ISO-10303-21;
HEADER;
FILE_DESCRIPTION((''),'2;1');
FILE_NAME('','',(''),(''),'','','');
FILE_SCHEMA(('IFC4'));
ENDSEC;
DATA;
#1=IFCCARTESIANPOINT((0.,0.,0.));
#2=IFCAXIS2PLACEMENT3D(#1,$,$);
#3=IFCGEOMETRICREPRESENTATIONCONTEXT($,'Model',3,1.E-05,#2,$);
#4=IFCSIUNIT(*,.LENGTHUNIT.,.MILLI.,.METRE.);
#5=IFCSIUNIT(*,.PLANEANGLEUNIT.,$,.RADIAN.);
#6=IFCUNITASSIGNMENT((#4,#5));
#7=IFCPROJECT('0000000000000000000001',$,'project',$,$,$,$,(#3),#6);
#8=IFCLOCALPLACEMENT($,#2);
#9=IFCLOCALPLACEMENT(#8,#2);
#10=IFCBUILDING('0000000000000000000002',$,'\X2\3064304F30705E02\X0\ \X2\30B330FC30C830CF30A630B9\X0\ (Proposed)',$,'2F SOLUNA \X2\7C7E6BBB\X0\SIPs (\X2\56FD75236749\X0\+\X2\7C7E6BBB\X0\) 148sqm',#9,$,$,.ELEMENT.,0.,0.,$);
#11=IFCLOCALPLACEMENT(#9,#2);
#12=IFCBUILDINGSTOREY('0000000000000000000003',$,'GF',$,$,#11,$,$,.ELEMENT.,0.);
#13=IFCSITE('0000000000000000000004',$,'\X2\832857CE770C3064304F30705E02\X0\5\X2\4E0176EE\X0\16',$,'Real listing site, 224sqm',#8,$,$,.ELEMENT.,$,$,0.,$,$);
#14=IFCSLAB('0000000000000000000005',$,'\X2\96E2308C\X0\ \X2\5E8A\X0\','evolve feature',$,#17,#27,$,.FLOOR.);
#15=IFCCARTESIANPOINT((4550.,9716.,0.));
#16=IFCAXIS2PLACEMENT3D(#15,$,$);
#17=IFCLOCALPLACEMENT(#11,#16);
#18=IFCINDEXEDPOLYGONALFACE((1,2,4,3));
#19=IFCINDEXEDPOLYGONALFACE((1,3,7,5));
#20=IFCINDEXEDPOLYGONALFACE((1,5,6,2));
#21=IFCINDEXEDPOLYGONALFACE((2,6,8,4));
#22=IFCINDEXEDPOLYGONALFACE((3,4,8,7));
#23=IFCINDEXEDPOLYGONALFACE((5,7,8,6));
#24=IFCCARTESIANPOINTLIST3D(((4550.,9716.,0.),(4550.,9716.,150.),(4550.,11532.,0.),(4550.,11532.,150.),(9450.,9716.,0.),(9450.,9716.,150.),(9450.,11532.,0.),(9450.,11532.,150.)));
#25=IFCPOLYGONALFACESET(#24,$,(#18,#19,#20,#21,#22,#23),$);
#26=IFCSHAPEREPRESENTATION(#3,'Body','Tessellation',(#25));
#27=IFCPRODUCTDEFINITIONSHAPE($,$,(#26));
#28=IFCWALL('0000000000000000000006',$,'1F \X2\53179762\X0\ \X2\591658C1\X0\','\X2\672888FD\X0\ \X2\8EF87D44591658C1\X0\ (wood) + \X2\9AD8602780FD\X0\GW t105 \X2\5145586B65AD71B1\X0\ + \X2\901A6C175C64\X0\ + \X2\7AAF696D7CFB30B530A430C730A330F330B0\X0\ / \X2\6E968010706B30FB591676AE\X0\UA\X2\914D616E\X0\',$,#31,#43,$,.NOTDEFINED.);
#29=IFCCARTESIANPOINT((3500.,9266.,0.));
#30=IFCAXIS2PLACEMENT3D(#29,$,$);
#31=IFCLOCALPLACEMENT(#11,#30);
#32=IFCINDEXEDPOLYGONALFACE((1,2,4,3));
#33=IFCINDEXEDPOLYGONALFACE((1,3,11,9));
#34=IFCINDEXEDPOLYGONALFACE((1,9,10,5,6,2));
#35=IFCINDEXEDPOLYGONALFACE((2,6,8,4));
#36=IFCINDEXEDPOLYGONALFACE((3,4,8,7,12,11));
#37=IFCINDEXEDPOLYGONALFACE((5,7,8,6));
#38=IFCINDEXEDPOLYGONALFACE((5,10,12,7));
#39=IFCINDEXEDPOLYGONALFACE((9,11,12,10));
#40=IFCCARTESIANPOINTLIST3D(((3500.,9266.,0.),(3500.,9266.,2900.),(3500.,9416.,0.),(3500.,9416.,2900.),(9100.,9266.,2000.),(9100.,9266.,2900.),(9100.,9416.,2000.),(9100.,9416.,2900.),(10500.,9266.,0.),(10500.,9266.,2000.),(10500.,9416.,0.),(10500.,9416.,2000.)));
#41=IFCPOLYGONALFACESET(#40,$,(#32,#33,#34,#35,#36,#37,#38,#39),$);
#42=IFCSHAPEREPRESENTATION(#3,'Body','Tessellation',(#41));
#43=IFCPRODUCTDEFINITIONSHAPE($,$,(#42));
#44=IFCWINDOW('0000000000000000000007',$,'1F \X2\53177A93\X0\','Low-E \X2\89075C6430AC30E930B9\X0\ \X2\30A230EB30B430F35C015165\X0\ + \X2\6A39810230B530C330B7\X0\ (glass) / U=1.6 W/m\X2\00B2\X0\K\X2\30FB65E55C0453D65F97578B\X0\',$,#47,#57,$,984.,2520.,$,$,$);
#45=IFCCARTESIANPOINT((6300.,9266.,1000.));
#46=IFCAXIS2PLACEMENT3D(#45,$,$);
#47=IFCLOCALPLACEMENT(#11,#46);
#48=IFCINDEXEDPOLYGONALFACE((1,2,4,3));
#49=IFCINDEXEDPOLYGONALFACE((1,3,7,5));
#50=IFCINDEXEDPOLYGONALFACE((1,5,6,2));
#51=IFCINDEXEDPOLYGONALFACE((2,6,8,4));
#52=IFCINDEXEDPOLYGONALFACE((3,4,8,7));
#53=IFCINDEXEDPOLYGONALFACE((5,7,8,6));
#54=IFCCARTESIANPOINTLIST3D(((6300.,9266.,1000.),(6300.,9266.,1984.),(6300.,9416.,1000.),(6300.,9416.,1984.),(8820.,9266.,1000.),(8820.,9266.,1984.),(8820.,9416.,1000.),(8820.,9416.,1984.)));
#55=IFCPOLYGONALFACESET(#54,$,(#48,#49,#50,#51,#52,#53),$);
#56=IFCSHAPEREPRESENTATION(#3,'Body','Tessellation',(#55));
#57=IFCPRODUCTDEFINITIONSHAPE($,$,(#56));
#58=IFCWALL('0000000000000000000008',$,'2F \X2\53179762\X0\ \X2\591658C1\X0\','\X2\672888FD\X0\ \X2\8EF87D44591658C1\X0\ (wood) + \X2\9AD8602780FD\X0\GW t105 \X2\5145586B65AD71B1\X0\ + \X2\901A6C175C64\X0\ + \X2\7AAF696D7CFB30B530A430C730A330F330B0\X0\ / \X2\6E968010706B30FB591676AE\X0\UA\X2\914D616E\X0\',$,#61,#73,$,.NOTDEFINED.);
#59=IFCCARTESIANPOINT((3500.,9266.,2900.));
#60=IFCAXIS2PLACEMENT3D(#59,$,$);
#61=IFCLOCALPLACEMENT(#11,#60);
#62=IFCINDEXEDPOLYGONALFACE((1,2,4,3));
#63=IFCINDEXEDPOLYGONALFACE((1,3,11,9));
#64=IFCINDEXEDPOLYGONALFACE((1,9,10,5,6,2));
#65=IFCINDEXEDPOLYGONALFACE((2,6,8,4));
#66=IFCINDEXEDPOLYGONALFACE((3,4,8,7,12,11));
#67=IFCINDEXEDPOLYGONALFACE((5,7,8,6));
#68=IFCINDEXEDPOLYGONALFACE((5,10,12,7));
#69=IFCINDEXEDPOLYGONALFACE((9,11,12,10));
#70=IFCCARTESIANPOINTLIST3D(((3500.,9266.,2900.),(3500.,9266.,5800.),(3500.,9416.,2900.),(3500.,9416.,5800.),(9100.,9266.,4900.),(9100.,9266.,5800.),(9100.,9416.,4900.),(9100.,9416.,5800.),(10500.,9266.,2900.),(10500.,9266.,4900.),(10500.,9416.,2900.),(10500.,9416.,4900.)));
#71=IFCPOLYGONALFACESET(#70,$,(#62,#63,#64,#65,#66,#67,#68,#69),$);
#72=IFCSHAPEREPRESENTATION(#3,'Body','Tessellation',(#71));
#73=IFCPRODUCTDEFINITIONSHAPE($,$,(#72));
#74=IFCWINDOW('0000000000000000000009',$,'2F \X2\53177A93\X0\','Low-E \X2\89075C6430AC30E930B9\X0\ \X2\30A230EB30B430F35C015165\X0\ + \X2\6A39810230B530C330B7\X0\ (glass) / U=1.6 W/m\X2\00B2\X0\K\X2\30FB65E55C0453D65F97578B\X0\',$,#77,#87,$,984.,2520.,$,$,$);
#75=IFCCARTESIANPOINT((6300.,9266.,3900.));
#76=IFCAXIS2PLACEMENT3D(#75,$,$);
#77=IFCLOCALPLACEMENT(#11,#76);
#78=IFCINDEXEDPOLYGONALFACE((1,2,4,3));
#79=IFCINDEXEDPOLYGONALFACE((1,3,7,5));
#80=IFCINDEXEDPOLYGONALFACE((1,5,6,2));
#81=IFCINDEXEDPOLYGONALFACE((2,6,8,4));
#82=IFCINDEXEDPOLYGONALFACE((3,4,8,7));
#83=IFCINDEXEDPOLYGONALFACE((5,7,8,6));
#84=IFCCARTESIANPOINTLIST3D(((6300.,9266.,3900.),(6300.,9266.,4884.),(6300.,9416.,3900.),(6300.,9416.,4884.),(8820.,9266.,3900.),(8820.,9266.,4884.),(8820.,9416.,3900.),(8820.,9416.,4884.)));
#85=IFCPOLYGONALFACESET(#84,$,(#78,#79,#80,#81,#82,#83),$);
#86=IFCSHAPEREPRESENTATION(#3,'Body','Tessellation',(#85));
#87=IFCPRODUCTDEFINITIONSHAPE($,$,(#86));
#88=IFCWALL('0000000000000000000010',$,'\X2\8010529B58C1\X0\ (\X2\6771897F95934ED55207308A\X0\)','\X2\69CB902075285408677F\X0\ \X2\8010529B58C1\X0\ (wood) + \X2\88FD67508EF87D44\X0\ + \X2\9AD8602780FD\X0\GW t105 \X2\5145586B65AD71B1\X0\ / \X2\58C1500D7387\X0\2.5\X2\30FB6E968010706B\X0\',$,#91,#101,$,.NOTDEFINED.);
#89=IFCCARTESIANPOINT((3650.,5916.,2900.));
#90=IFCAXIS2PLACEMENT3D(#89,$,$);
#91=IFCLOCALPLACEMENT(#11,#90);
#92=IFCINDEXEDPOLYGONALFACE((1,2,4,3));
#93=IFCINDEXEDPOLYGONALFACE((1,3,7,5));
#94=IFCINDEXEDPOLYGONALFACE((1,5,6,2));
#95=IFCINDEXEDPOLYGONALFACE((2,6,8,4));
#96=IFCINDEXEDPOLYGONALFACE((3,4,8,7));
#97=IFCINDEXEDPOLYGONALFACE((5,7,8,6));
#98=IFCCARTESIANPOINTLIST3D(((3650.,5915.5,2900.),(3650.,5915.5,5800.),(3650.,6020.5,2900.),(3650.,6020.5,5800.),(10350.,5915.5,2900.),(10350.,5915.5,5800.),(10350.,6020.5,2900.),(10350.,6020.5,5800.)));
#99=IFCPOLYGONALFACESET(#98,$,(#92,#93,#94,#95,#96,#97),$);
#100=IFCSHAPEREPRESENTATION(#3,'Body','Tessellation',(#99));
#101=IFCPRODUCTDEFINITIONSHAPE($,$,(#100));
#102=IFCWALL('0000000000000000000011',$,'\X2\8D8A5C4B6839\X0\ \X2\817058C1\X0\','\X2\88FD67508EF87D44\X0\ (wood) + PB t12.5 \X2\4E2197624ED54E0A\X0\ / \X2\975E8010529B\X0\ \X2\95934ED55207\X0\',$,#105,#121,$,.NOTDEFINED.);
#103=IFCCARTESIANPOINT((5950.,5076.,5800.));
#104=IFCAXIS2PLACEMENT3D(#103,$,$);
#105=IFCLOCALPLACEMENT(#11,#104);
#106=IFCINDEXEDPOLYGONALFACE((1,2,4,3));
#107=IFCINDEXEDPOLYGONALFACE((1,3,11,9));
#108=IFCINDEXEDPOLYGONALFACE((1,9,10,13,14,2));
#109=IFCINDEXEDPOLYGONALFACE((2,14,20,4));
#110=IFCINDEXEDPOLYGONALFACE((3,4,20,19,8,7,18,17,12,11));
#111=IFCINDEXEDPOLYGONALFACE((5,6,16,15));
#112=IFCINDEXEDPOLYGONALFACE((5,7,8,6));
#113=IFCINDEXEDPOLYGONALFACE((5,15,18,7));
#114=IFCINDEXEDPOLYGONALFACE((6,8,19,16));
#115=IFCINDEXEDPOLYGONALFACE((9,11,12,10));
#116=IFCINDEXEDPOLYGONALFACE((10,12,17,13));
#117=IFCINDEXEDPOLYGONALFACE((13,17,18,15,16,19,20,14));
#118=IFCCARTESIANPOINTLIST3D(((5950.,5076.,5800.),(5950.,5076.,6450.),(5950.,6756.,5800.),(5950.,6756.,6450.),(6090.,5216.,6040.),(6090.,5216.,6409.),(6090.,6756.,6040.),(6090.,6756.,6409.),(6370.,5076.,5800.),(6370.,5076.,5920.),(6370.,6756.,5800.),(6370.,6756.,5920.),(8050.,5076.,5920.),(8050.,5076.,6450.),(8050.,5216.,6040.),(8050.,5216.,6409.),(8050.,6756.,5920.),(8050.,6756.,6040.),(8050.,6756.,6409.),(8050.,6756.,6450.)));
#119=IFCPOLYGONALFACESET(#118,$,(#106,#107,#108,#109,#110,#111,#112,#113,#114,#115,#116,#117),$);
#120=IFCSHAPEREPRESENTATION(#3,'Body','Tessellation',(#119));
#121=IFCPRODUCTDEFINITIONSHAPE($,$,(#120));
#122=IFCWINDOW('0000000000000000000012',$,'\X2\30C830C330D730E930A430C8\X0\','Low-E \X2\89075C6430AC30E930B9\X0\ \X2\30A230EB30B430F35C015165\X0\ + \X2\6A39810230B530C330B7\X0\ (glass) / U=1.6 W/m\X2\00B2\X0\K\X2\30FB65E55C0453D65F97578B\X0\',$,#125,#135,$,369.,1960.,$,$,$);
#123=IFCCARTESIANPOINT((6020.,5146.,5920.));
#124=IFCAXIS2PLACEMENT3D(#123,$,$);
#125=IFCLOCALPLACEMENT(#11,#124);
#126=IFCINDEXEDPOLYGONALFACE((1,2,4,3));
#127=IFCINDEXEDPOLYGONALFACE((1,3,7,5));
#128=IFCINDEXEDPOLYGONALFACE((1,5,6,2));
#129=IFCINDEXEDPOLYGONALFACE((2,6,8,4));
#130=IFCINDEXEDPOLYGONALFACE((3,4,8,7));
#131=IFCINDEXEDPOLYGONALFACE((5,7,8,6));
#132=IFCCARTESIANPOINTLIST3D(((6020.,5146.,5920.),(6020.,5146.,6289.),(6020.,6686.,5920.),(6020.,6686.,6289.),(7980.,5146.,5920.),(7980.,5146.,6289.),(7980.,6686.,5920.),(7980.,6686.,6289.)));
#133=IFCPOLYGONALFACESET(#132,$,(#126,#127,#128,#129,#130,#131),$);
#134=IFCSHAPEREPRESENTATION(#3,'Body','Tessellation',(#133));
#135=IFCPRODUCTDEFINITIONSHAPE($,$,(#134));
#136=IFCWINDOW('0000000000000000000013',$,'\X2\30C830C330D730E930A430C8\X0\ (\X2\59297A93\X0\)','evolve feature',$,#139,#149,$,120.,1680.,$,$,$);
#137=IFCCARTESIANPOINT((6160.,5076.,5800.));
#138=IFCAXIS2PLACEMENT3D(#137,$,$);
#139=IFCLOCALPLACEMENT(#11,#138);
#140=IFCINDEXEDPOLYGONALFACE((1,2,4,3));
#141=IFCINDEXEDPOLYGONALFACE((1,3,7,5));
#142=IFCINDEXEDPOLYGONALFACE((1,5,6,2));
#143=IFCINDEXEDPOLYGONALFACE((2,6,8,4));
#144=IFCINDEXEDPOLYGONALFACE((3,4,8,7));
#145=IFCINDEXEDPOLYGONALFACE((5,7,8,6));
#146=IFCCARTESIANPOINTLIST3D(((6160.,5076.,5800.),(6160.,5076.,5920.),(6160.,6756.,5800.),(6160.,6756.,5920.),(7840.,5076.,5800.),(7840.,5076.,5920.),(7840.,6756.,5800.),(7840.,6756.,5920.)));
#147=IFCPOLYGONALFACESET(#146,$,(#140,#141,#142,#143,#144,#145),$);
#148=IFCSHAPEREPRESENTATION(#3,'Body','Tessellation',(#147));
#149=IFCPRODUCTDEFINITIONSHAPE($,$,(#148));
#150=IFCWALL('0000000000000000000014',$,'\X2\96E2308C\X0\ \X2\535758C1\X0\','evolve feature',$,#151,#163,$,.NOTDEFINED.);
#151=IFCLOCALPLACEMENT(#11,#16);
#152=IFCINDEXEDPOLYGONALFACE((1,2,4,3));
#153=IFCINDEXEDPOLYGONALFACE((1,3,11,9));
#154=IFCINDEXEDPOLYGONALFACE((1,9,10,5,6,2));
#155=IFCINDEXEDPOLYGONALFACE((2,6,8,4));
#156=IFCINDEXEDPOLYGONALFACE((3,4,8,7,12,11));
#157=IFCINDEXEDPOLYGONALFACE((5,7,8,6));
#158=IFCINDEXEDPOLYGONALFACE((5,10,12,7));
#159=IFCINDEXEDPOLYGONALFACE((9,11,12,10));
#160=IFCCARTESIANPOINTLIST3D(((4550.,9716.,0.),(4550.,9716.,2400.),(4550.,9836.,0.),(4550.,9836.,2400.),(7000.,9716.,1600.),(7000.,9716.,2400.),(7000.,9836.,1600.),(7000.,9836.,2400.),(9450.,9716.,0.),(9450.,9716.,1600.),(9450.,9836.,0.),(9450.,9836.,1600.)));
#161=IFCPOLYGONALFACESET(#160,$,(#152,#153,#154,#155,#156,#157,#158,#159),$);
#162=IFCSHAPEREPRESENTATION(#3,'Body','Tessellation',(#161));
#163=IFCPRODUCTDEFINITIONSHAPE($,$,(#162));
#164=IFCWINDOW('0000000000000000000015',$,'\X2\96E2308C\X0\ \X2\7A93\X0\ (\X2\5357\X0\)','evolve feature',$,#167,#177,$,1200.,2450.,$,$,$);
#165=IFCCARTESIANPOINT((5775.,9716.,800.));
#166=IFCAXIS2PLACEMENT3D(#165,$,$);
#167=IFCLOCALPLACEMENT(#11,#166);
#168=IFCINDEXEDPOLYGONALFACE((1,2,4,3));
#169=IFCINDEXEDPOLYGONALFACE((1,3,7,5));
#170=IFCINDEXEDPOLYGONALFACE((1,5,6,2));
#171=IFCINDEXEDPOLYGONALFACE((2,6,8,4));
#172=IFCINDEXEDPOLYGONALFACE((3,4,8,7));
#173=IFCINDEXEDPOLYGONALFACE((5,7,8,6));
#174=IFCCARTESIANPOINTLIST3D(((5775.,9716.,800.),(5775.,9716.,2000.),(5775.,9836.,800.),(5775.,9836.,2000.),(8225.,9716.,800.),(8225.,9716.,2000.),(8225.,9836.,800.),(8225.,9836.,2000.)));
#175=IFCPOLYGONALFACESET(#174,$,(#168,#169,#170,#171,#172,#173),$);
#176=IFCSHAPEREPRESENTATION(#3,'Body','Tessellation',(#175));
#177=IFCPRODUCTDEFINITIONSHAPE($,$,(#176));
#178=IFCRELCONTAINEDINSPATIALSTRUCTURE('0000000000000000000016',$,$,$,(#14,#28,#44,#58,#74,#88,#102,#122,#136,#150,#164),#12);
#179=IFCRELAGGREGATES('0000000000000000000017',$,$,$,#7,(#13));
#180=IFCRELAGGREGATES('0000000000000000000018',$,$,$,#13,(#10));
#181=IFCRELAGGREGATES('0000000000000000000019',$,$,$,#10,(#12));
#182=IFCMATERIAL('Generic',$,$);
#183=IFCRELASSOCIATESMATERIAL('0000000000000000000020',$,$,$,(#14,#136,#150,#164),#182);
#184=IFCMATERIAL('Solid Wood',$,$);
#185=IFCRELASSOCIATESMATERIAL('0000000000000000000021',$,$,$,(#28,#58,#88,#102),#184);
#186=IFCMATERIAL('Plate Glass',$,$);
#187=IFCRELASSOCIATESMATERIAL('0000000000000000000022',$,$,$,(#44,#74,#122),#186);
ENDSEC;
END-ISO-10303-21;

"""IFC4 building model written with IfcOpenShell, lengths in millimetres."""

from ifc_helpers import new_model, si_unit, frame, frame_2d, origin, place, context, project, spatial, rectangle, extrude, material, element, fill, save


model = new_model("IFC4")

# Units and contexts
model_context = context("Model", 3, precision=1e-05, world=origin())
ifc_project = project(units=[si_unit("LENGTHUNIT", "METRE", prefix="MILLI"), si_unit("PLANEANGLEUNIT", "RADIAN")], contexts=[model_context])

# Site, building, storey
site_placement = place(None, origin())
site = spatial("IfcSite", under=ifc_project, at=site_placement, Name="茨城県つくば市5丁目16", ObjectType="Real listing site, 224sqm", CompositionType="ELEMENT", RefElevation=0.0)
building_placement = place(site_placement, origin())
building = spatial("IfcBuilding", under=site, at=building_placement, Name="つくば市 コートハウス (Proposed)", ObjectType="2F SOLUNA 籾殻SIPs (国産杉+籾殻) 148sqm", CompositionType="ELEMENT", ElevationOfRefHeight=0.0, ElevationOfTerrain=0.0)
storey_placement = place(building_placement, origin())
storey = spatial("IfcBuildingStorey", under=building, at=storey_placement, Name="GF", CompositionType="ELEMENT", Elevation=0.0)

# Slab
ifc_material_1 = material(Name="Generic")
slab_placement = place(storey_placement, frame((4550.0, 9716.0, 0.0)))
element("IfcSlab", 1, at=slab_placement, inside=storey, material=ifc_material_1, Name="離れ 床", Description="evolve feature", PredefinedType="FLOOR", context=model_context, shape_type="SweptSolid", body=[
    extrude(rectangle(XDim=4900.0, YDim=1816.0, at=frame_2d((2450.0, 908.0))), frame((4550.0, 9716.0, 0.0)), (0.0, 0.0, 1.0), 150.0),
])

# Wall, opening, window
ifc_material_2 = material(Name="Solid Wood")
wall_1_placement = place(storey_placement, frame((3500.0, 9266.0, 0.0)))
wall_1 = element("IfcWall", 2, at=wall_1_placement, inside=storey, material=ifc_material_2, Name="1F 北面 外壁", Description="木製 軸組外壁 (wood) + 高性能GW t105 充填断熱 + 通気層 + 窯業系サイディング / 準耐火・外皮UA配慮", PredefinedType="NOTDEFINED", context=model_context, shape_type="SweptSolid", body=[
    extrude(rectangle(XDim=7000.0, YDim=150.0, at=frame_2d((3500.0, 75.0))), frame((3500.0, 9266.0, 0.0)), (0.0, 0.0, 1.0), 2900.0),
])
opening_1_placement = place(storey_placement, frame((6300.0, 9266.0, 1000.0)))
opening_1 = element("IfcOpeningElement", 3, at=opening_1_placement, cuts=wall_1, PredefinedType="NOTDEFINED", context=model_context, shape_type="SweptSolid", body=[
    extrude(rectangle(XDim=2520.0, YDim=150.0, at=frame_2d((1260.0, 75.0))), frame((6300.0, 9266.0, 1000.0)), (0.0, 0.0, 1.0), 984.0),
])
ifc_material_3 = material(Name="Plate Glass")
window_1_placement = place(storey_placement, frame((6300.0, 9266.0, 1000.0)))
window_1 = element("IfcWindow", 4, at=window_1_placement, inside=storey, material=ifc_material_3, Name="1F 北窓", Description="Low-E 複層ガラス アルゴン封入 + 樹脂サッシ (glass) / U=1.6 W/m²K・日射取得型", OverallHeight=984.0, OverallWidth=2520.0, context=model_context, shape_type="SweptSolid", body=[
    extrude(rectangle(XDim=2520.0, YDim=150.0, at=frame_2d((1260.0, 75.0))), frame((6300.0, 9266.0, 1000.0)), (0.0, 0.0, 1.0), 984.0),
])
fill(opening_1, window_1)

# Wall, opening, window
wall_2_placement = place(storey_placement, frame((3500.0, 9266.0, 2900.0)))
wall_2 = element("IfcWall", 5, at=wall_2_placement, inside=storey, material=ifc_material_2, Name="2F 北面 外壁", Description="木製 軸組外壁 (wood) + 高性能GW t105 充填断熱 + 通気層 + 窯業系サイディング / 準耐火・外皮UA配慮", PredefinedType="NOTDEFINED", context=model_context, shape_type="SweptSolid", body=[
    extrude(rectangle(XDim=7000.0, YDim=150.0, at=frame_2d((3500.0, 75.0))), frame((3500.0, 9266.0, 2900.0)), (0.0, 0.0, 1.0), 2900.0),
])
opening_2_placement = place(storey_placement, frame((6300.0, 9266.0, 3900.0)))
opening_2 = element("IfcOpeningElement", 6, at=opening_2_placement, cuts=wall_2, PredefinedType="NOTDEFINED", context=model_context, shape_type="SweptSolid", body=[
    extrude(rectangle(XDim=2520.0, YDim=150.0, at=frame_2d((1260.0, 75.0))), frame((6300.0, 9266.0, 3900.0)), (0.0, 0.0, 1.0), 984.0),
])
window_2_placement = place(storey_placement, frame((6300.0, 9266.0, 3900.0)))
window_2 = element("IfcWindow", 7, at=window_2_placement, inside=storey, material=ifc_material_3, Name="2F 北窓", Description="Low-E 複層ガラス アルゴン封入 + 樹脂サッシ (glass) / U=1.6 W/m²K・日射取得型", OverallHeight=984.0, OverallWidth=2520.0, context=model_context, shape_type="SweptSolid", body=[
    extrude(rectangle(XDim=2520.0, YDim=150.0, at=frame_2d((1260.0, 75.0))), frame((6300.0, 9266.0, 3900.0)), (0.0, 0.0, 1.0), 984.0),
])
fill(opening_2, window_2)

# Wall
wall_3_placement = place(storey_placement, frame((3650.0, 5916.0, 2900.0)))
element("IfcWall", 8, at=wall_3_placement, inside=storey, material=ifc_material_2, Name="耐力壁 (東西間仕切り)", Description="構造用合板 耐力壁 (wood) + 製材軸組 + 高性能GW t105 充填断熱 / 壁倍率2.5・準耐火", PredefinedType="NOTDEFINED", context=model_context, shape_type="SweptSolid", body=[
    extrude(rectangle(XDim=6700.0, YDim=105.0, at=frame_2d((3350.0, 52.0))), frame((3650.0, 5916.0, 2900.0)), (0.0, 0.0, 1.0), 2900.0),
])

# Wall, openings, windows
wall_4_placement = place(storey_placement, frame((5950.0, 5076.0, 5800.0)))
wall_4 = element("IfcWall", 9, at=wall_4_placement, inside=storey, material=ifc_material_2, Name="越屋根 腰壁", Description="製材軸組 (wood) + PB t12.5 両面仕上 / 非耐力 間仕切", PredefinedType="NOTDEFINED", context=model_context, shape_type="SweptSolid", body=[
    extrude(rectangle(XDim=2100.0, YDim=1680.0, at=frame_2d((1050.0, 840.0))), frame((5950.0, 5076.0, 5800.0)), (0.0, 0.0, 1.0), 650.0),
])
opening_3_placement = place(storey_placement, frame((6020.0, 5146.0, 5920.0)))
opening_3 = element("IfcOpeningElement", 10, at=opening_3_placement, cuts=wall_4, PredefinedType="NOTDEFINED", context=model_context, shape_type="SweptSolid", body=[
    extrude(rectangle(XDim=1960.0, YDim=1540.0, at=frame_2d((980.0, 770.0))), frame((6020.0, 5146.0, 5920.0)), (0.0, 0.0, 1.0), 369.0),
])
opening_4_placement = place(storey_placement, frame((6160.0, 5076.0, 5800.0)))
opening_4 = element("IfcOpeningElement", 11, at=opening_4_placement, cuts=wall_4, PredefinedType="NOTDEFINED", context=model_context, shape_type="SweptSolid", body=[
    extrude(rectangle(XDim=1680.0, YDim=1680.0, at=frame_2d((840.0, 840.0))), frame((6160.0, 5076.0, 5800.0)), (0.0, 0.0, 1.0), 120.0),
])
window_3_placement = place(storey_placement, frame((6020.0, 5146.0, 5920.0)))
window_3 = element("IfcWindow", 12, at=window_3_placement, inside=storey, material=ifc_material_3, Name="トップライト", Description="Low-E 複層ガラス アルゴン封入 + 樹脂サッシ (glass) / U=1.6 W/m²K・日射取得型", OverallHeight=369.0, OverallWidth=1960.0, context=model_context, shape_type="SweptSolid", body=[
    extrude(rectangle(XDim=1960.0, YDim=1540.0, at=frame_2d((980.0, 770.0))), frame((6020.0, 5146.0, 5920.0)), (0.0, 0.0, 1.0), 369.0),
])
fill(opening_3, window_3)
window_4_placement = place(storey_placement, frame((6160.0, 5076.0, 5800.0)))
window_4 = element("IfcWindow", 13, at=window_4_placement, inside=storey, material=ifc_material_1, Name="トップライト (天窓)", Description="evolve feature", OverallHeight=120.0, OverallWidth=1680.0, context=model_context, shape_type="SweptSolid", body=[
    extrude(rectangle(XDim=1680.0, YDim=1680.0, at=frame_2d((840.0, 840.0))), frame((6160.0, 5076.0, 5800.0)), (0.0, 0.0, 1.0), 120.0),
])
fill(opening_4, window_4)

# Wall, opening, window
wall_5_placement = place(storey_placement, frame((4550.0, 9716.0, 0.0)))
wall_5 = element("IfcWall", 14, at=wall_5_placement, inside=storey, material=ifc_material_1, Name="離れ 南壁", Description="evolve feature", PredefinedType="NOTDEFINED", context=model_context, shape_type="SweptSolid", body=[
    extrude(rectangle(XDim=4900.0, YDim=120.0, at=frame_2d((2450.0, 60.0))), frame((4550.0, 9716.0, 0.0)), (0.0, 0.0, 1.0), 2400.0),
])
opening_5_placement = place(storey_placement, frame((5775.0, 9716.0, 800.0)))
opening_5 = element("IfcOpeningElement", 15, at=opening_5_placement, cuts=wall_5, PredefinedType="NOTDEFINED", context=model_context, shape_type="SweptSolid", body=[
    extrude(rectangle(XDim=2450.0, YDim=120.0, at=frame_2d((1225.0, 60.0))), frame((5775.0, 9716.0, 800.0)), (0.0, 0.0, 1.0), 1200.0),
])
window_5_placement = place(storey_placement, frame((5775.0, 9716.0, 800.0)))
window_5 = element("IfcWindow", 16, at=window_5_placement, inside=storey, material=ifc_material_1, Name="離れ 窓 (南)", Description="evolve feature", OverallHeight=1200.0, OverallWidth=2450.0, context=model_context, shape_type="SweptSolid", body=[
    extrude(rectangle(XDim=2450.0, YDim=120.0, at=frame_2d((1225.0, 60.0))), frame((5775.0, 9716.0, 800.0)), (0.0, 0.0, 1.0), 1200.0),
])
fill(opening_5, window_5)

save(model, "model.ifc")
